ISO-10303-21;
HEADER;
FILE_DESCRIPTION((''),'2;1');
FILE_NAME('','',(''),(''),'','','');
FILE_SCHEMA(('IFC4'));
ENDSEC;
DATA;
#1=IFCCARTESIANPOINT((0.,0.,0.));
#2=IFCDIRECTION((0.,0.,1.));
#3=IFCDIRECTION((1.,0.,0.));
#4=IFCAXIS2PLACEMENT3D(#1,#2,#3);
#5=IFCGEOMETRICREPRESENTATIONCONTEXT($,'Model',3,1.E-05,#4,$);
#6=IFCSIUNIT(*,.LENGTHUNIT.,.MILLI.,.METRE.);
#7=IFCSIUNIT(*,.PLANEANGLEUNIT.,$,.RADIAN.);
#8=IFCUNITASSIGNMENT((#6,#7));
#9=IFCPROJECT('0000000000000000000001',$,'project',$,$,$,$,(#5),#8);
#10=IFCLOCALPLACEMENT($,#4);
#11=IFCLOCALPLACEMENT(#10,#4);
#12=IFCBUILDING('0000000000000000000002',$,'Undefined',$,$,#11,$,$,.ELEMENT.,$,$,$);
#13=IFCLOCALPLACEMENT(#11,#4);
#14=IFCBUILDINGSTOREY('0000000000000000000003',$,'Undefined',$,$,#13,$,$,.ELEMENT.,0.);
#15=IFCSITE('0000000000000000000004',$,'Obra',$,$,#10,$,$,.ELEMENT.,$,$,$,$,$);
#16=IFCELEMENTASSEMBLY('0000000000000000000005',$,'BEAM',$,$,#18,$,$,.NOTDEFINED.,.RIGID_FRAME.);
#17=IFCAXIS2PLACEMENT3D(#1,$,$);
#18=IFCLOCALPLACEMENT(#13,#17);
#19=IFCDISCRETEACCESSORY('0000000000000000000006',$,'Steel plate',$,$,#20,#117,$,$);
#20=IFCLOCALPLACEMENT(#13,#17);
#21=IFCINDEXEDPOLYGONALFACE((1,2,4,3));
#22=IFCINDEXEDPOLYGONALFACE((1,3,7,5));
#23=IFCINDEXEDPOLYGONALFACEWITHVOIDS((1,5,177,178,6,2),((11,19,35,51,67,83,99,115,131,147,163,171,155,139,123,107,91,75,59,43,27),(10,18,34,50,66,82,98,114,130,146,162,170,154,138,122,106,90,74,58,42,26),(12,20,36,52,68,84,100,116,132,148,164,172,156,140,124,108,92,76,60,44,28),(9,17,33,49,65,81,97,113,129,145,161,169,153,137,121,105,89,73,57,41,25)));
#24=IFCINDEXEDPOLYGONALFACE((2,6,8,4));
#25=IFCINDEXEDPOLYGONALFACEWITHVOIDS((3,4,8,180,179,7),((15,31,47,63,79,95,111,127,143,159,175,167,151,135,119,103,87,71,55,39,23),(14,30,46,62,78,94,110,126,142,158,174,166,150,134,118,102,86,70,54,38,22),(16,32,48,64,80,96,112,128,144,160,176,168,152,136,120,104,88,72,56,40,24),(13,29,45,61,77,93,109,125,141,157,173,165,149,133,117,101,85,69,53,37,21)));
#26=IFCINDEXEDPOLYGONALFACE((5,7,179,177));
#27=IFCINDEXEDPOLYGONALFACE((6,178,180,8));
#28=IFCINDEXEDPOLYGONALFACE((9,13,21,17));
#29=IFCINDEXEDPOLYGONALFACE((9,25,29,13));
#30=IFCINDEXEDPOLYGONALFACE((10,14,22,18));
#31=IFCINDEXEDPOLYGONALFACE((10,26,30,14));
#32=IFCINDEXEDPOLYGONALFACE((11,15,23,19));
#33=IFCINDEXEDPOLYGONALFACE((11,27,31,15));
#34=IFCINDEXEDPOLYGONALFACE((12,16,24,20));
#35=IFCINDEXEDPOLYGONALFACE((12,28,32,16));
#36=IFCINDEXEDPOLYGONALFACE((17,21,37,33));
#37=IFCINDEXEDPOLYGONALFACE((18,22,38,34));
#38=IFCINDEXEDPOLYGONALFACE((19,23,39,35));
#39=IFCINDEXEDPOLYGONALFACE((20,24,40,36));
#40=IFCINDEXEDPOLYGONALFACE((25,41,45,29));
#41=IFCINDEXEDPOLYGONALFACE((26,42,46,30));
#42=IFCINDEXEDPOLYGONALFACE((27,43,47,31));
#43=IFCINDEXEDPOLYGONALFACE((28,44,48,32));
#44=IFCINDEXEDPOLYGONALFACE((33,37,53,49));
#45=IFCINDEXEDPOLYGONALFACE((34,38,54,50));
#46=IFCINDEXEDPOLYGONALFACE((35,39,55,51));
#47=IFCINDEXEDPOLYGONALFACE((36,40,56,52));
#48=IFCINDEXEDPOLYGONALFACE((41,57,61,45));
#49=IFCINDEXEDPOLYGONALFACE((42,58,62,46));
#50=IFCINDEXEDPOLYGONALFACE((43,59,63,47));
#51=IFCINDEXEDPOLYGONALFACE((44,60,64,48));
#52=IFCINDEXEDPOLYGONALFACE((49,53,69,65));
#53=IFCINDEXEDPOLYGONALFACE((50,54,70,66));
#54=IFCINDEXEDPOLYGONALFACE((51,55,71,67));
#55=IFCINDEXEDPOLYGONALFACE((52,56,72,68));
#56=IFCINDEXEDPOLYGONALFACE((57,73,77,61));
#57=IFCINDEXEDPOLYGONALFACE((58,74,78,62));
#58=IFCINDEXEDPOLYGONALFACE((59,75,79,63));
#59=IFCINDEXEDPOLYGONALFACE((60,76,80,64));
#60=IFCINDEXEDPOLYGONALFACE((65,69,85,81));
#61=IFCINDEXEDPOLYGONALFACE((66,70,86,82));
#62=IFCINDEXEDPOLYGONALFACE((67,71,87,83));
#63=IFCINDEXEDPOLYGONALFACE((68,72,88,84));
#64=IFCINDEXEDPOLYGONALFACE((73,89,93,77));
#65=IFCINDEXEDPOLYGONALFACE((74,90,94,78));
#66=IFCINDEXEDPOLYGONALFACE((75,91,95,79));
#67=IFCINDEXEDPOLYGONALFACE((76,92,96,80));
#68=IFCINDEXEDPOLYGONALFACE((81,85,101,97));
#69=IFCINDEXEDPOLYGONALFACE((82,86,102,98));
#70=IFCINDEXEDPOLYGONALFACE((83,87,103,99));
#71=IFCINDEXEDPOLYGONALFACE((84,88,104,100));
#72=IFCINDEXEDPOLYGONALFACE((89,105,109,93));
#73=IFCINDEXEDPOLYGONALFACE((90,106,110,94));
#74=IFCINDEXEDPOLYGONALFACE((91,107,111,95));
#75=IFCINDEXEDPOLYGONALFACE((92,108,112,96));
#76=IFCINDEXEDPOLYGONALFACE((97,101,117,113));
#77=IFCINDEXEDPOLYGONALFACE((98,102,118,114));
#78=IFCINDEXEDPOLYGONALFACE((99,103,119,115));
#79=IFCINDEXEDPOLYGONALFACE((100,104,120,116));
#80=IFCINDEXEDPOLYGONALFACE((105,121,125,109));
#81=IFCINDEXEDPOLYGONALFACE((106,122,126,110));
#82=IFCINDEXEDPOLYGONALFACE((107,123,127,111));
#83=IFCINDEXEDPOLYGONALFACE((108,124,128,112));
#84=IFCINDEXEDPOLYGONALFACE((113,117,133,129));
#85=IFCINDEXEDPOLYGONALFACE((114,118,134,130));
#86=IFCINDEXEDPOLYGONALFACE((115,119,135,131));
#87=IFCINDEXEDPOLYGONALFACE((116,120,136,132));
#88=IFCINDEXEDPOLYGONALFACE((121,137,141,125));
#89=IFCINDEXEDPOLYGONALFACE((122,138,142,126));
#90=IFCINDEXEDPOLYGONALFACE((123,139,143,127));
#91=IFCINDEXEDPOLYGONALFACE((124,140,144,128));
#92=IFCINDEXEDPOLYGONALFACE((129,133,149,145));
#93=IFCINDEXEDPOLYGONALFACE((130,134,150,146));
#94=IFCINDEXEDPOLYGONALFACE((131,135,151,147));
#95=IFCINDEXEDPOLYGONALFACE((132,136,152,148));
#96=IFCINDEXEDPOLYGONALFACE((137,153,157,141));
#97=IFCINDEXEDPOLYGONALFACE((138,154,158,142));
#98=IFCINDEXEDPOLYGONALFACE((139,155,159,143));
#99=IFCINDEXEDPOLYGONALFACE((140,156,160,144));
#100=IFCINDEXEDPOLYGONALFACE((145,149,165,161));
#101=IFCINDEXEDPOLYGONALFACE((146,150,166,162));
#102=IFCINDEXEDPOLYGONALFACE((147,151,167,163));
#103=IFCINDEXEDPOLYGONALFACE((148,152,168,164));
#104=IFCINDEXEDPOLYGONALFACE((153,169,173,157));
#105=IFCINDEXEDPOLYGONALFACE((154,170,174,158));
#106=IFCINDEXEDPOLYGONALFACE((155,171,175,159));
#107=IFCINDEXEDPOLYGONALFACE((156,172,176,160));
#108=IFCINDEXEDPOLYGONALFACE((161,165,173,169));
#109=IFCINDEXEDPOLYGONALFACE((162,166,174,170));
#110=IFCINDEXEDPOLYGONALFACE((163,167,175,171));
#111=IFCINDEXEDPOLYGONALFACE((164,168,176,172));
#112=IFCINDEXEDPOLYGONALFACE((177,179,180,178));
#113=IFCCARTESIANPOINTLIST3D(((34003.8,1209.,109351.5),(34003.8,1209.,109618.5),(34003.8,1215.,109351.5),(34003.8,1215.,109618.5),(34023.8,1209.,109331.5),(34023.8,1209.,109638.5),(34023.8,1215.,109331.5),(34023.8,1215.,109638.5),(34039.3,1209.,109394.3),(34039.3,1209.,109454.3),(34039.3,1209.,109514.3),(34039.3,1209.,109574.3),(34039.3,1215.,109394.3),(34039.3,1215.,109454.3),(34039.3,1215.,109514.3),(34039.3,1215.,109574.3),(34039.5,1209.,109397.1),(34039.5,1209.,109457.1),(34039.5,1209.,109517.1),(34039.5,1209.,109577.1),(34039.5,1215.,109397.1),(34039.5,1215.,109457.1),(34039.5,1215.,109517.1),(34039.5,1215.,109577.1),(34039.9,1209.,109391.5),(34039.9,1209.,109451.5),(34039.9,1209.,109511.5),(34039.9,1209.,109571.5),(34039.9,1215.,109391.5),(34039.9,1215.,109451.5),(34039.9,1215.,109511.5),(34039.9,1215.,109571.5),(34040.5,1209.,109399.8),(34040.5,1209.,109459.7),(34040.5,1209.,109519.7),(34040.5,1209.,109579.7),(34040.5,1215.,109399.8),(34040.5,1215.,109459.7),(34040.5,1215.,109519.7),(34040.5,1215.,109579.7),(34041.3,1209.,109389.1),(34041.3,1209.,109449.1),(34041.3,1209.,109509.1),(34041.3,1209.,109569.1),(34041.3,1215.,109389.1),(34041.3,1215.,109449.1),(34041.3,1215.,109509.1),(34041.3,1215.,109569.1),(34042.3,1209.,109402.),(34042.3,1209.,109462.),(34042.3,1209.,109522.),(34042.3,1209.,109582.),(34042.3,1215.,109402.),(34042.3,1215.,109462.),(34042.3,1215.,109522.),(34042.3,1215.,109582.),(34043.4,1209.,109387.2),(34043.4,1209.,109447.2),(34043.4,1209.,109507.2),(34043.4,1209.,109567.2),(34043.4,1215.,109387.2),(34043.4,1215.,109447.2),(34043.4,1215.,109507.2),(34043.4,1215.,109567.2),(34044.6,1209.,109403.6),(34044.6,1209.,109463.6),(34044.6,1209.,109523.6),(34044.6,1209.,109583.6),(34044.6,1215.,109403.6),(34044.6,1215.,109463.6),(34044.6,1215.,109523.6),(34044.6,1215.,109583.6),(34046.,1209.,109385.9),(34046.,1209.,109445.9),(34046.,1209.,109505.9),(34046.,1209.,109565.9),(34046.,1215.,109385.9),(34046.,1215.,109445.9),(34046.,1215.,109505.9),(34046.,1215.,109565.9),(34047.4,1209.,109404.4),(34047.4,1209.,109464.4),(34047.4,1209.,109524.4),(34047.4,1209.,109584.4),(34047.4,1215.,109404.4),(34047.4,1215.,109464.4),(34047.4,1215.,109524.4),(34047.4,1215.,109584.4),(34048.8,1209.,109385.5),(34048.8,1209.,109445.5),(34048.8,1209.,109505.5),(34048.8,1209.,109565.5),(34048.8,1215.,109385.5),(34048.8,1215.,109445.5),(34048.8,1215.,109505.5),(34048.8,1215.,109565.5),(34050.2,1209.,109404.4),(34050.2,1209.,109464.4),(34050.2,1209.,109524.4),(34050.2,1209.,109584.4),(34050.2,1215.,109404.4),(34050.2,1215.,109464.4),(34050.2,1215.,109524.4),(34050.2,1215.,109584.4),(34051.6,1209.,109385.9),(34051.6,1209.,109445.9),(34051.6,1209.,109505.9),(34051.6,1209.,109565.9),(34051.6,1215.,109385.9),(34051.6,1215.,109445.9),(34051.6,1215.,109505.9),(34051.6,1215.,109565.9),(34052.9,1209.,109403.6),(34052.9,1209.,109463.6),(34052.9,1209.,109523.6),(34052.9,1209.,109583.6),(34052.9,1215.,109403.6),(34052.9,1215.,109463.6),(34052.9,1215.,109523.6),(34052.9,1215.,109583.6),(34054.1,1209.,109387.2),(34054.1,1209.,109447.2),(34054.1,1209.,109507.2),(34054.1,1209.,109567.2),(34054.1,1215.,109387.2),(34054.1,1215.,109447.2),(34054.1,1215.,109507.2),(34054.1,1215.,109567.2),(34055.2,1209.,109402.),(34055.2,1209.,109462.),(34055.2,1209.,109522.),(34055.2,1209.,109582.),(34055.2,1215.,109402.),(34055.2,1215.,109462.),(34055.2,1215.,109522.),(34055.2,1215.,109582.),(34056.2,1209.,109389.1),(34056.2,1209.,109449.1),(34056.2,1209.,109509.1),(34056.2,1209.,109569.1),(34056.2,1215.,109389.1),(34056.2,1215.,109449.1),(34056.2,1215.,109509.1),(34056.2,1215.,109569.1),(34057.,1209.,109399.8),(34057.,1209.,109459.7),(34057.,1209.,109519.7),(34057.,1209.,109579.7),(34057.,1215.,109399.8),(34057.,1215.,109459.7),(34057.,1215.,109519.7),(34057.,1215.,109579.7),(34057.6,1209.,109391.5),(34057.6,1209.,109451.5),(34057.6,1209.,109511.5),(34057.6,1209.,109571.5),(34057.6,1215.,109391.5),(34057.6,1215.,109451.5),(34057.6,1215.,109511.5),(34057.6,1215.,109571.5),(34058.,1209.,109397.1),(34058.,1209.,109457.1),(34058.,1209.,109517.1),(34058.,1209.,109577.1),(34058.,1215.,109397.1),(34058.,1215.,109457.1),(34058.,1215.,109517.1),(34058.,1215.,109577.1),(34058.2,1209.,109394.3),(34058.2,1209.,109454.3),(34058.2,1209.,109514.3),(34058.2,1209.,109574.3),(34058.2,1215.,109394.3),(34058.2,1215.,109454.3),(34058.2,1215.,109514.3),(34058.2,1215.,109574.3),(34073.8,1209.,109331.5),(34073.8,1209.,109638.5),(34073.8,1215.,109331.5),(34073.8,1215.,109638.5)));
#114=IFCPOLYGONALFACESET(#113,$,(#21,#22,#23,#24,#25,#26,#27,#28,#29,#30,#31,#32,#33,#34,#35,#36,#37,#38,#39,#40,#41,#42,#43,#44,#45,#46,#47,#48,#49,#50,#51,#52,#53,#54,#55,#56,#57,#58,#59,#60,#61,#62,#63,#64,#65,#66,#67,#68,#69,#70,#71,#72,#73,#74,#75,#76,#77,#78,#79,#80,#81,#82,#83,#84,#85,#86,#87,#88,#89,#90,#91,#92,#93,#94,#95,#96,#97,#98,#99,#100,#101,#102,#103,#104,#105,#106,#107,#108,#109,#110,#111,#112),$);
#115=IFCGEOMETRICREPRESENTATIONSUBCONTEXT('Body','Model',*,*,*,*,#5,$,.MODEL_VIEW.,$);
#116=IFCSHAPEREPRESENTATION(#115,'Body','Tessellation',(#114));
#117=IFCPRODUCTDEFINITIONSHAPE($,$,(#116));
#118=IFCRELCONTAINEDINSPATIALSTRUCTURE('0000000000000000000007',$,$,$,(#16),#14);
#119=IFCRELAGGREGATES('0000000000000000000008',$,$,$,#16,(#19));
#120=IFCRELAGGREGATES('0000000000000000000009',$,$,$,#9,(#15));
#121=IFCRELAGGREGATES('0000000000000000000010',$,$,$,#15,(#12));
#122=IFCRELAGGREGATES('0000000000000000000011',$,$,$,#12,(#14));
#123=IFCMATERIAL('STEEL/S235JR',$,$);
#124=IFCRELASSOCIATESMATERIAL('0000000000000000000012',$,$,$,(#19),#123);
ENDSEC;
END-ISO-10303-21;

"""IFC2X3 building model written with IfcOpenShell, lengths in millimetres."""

from ifc_helpers import new_model, si_unit, frame, origin_with_axes, origin_2d_with_axis, place, context, subcontext, project, spatial, polyline, circle, outline, extrude, source, transform, mapped, material, element, aggregate, save


model = new_model("IFC2X3")

# Units and contexts
model_context = context("Model", 3, precision=1e-05, world=origin_with_axes())
body_context = subcontext(model_context, "Body", "Model", "MODEL_VIEW")
ifc_project = project(units=[si_unit("LENGTHUNIT", "METRE", prefix="MILLI"), si_unit("PLANEANGLEUNIT", "RADIAN")], contexts=[model_context])

# Site, building, storey
site_placement = place(None, origin_with_axes())
site = spatial("IfcSite", under=ifc_project, at=site_placement, Name="Obra", CompositionType="ELEMENT")
building_placement = place(site_placement, origin_with_axes())
building = spatial("IfcBuilding", under=site, at=building_placement, Name="Undefined", CompositionType="ELEMENT")
storey_placement = place(building_placement, origin_with_axes())
storey = spatial("IfcBuildingStorey", under=building, at=storey_placement, Name="Undefined", CompositionType="ELEMENT", Elevation=0.0)

# Element assembly, discrete accessory, opening
assembly_1_placement = place(storey_placement, origin_with_axes())
assembly_1 = element("IfcElementAssembly", 1, at=assembly_1_placement, inside=storey, Name="BEAM", AssemblyPlace="NOTDEFINED", PredefinedType="RIGID_FRAME")
ifc_material = material(Name="STEEL/S235JR")
shared_shape = source(origin_with_axes(), body_context, "Body", "SweptSolid", [
    extrude(circle(Radius=9.5, at=origin_2d_with_axis()), frame((0.0, -9.8, 0.0), z_axis=(0.0, 1.0, 0.0), x_axis=(1.0, 0.0, 0.0)), (0.0, 0.0, 1.0), 6.2),
])
discrete_accessory_1_placement = place(assembly_1_placement, frame((34073.8, 1212.0, 109331.5), z_axis=(-0.000002, 1.0, 0.0), x_axis=(-1.0, -0.000002, 0.0)))
discrete_accessory_1 = element("IfcDiscreteAccessory", 2, at=discrete_accessory_1_placement, material=ifc_material, Name="Steel plate", context=body_context, shape_type="SweptSolid", body=[
    extrude(outline(polyline([(0.0, 0.0), (50.0, 0.0), (70.0, 20.0), (70.0, 287.0), (50.0, 307.0), (0.0, 307.0), (0.0, 0.0)])), frame((0.0, 0.0, -3.0), z_axis=(0.0, 0.0, 1.0), x_axis=(1.0, 0.0, 0.0)), (0.0, 0.0, 1.0), 6.0),
])
opening_1_placement = place(assembly_1_placement, frame((34013.8, 1218.7, 109650.0), z_axis=(1.0, 0.000002, 0.0), x_axis=(0.0, 0.0, -1.0)))
element("IfcOpeningElement", 3, at=opening_1_placement, cuts=discrete_accessory_1, ObjectType="Opening", context=body_context, shape_type="MappedRepresentation", body=[
    mapped(shared_shape, transform((75.0, 0.0, 35.0))),
    mapped(shared_shape, transform((135.0, 0.0, 35.0))),
    mapped(shared_shape, transform((195.0, 0.0, 35.0))),
    mapped(shared_shape, transform((255.0, 0.0, 35.0))),
])
aggregate(assembly_1, [discrete_accessory_1])

save(model, "model.ifc")
